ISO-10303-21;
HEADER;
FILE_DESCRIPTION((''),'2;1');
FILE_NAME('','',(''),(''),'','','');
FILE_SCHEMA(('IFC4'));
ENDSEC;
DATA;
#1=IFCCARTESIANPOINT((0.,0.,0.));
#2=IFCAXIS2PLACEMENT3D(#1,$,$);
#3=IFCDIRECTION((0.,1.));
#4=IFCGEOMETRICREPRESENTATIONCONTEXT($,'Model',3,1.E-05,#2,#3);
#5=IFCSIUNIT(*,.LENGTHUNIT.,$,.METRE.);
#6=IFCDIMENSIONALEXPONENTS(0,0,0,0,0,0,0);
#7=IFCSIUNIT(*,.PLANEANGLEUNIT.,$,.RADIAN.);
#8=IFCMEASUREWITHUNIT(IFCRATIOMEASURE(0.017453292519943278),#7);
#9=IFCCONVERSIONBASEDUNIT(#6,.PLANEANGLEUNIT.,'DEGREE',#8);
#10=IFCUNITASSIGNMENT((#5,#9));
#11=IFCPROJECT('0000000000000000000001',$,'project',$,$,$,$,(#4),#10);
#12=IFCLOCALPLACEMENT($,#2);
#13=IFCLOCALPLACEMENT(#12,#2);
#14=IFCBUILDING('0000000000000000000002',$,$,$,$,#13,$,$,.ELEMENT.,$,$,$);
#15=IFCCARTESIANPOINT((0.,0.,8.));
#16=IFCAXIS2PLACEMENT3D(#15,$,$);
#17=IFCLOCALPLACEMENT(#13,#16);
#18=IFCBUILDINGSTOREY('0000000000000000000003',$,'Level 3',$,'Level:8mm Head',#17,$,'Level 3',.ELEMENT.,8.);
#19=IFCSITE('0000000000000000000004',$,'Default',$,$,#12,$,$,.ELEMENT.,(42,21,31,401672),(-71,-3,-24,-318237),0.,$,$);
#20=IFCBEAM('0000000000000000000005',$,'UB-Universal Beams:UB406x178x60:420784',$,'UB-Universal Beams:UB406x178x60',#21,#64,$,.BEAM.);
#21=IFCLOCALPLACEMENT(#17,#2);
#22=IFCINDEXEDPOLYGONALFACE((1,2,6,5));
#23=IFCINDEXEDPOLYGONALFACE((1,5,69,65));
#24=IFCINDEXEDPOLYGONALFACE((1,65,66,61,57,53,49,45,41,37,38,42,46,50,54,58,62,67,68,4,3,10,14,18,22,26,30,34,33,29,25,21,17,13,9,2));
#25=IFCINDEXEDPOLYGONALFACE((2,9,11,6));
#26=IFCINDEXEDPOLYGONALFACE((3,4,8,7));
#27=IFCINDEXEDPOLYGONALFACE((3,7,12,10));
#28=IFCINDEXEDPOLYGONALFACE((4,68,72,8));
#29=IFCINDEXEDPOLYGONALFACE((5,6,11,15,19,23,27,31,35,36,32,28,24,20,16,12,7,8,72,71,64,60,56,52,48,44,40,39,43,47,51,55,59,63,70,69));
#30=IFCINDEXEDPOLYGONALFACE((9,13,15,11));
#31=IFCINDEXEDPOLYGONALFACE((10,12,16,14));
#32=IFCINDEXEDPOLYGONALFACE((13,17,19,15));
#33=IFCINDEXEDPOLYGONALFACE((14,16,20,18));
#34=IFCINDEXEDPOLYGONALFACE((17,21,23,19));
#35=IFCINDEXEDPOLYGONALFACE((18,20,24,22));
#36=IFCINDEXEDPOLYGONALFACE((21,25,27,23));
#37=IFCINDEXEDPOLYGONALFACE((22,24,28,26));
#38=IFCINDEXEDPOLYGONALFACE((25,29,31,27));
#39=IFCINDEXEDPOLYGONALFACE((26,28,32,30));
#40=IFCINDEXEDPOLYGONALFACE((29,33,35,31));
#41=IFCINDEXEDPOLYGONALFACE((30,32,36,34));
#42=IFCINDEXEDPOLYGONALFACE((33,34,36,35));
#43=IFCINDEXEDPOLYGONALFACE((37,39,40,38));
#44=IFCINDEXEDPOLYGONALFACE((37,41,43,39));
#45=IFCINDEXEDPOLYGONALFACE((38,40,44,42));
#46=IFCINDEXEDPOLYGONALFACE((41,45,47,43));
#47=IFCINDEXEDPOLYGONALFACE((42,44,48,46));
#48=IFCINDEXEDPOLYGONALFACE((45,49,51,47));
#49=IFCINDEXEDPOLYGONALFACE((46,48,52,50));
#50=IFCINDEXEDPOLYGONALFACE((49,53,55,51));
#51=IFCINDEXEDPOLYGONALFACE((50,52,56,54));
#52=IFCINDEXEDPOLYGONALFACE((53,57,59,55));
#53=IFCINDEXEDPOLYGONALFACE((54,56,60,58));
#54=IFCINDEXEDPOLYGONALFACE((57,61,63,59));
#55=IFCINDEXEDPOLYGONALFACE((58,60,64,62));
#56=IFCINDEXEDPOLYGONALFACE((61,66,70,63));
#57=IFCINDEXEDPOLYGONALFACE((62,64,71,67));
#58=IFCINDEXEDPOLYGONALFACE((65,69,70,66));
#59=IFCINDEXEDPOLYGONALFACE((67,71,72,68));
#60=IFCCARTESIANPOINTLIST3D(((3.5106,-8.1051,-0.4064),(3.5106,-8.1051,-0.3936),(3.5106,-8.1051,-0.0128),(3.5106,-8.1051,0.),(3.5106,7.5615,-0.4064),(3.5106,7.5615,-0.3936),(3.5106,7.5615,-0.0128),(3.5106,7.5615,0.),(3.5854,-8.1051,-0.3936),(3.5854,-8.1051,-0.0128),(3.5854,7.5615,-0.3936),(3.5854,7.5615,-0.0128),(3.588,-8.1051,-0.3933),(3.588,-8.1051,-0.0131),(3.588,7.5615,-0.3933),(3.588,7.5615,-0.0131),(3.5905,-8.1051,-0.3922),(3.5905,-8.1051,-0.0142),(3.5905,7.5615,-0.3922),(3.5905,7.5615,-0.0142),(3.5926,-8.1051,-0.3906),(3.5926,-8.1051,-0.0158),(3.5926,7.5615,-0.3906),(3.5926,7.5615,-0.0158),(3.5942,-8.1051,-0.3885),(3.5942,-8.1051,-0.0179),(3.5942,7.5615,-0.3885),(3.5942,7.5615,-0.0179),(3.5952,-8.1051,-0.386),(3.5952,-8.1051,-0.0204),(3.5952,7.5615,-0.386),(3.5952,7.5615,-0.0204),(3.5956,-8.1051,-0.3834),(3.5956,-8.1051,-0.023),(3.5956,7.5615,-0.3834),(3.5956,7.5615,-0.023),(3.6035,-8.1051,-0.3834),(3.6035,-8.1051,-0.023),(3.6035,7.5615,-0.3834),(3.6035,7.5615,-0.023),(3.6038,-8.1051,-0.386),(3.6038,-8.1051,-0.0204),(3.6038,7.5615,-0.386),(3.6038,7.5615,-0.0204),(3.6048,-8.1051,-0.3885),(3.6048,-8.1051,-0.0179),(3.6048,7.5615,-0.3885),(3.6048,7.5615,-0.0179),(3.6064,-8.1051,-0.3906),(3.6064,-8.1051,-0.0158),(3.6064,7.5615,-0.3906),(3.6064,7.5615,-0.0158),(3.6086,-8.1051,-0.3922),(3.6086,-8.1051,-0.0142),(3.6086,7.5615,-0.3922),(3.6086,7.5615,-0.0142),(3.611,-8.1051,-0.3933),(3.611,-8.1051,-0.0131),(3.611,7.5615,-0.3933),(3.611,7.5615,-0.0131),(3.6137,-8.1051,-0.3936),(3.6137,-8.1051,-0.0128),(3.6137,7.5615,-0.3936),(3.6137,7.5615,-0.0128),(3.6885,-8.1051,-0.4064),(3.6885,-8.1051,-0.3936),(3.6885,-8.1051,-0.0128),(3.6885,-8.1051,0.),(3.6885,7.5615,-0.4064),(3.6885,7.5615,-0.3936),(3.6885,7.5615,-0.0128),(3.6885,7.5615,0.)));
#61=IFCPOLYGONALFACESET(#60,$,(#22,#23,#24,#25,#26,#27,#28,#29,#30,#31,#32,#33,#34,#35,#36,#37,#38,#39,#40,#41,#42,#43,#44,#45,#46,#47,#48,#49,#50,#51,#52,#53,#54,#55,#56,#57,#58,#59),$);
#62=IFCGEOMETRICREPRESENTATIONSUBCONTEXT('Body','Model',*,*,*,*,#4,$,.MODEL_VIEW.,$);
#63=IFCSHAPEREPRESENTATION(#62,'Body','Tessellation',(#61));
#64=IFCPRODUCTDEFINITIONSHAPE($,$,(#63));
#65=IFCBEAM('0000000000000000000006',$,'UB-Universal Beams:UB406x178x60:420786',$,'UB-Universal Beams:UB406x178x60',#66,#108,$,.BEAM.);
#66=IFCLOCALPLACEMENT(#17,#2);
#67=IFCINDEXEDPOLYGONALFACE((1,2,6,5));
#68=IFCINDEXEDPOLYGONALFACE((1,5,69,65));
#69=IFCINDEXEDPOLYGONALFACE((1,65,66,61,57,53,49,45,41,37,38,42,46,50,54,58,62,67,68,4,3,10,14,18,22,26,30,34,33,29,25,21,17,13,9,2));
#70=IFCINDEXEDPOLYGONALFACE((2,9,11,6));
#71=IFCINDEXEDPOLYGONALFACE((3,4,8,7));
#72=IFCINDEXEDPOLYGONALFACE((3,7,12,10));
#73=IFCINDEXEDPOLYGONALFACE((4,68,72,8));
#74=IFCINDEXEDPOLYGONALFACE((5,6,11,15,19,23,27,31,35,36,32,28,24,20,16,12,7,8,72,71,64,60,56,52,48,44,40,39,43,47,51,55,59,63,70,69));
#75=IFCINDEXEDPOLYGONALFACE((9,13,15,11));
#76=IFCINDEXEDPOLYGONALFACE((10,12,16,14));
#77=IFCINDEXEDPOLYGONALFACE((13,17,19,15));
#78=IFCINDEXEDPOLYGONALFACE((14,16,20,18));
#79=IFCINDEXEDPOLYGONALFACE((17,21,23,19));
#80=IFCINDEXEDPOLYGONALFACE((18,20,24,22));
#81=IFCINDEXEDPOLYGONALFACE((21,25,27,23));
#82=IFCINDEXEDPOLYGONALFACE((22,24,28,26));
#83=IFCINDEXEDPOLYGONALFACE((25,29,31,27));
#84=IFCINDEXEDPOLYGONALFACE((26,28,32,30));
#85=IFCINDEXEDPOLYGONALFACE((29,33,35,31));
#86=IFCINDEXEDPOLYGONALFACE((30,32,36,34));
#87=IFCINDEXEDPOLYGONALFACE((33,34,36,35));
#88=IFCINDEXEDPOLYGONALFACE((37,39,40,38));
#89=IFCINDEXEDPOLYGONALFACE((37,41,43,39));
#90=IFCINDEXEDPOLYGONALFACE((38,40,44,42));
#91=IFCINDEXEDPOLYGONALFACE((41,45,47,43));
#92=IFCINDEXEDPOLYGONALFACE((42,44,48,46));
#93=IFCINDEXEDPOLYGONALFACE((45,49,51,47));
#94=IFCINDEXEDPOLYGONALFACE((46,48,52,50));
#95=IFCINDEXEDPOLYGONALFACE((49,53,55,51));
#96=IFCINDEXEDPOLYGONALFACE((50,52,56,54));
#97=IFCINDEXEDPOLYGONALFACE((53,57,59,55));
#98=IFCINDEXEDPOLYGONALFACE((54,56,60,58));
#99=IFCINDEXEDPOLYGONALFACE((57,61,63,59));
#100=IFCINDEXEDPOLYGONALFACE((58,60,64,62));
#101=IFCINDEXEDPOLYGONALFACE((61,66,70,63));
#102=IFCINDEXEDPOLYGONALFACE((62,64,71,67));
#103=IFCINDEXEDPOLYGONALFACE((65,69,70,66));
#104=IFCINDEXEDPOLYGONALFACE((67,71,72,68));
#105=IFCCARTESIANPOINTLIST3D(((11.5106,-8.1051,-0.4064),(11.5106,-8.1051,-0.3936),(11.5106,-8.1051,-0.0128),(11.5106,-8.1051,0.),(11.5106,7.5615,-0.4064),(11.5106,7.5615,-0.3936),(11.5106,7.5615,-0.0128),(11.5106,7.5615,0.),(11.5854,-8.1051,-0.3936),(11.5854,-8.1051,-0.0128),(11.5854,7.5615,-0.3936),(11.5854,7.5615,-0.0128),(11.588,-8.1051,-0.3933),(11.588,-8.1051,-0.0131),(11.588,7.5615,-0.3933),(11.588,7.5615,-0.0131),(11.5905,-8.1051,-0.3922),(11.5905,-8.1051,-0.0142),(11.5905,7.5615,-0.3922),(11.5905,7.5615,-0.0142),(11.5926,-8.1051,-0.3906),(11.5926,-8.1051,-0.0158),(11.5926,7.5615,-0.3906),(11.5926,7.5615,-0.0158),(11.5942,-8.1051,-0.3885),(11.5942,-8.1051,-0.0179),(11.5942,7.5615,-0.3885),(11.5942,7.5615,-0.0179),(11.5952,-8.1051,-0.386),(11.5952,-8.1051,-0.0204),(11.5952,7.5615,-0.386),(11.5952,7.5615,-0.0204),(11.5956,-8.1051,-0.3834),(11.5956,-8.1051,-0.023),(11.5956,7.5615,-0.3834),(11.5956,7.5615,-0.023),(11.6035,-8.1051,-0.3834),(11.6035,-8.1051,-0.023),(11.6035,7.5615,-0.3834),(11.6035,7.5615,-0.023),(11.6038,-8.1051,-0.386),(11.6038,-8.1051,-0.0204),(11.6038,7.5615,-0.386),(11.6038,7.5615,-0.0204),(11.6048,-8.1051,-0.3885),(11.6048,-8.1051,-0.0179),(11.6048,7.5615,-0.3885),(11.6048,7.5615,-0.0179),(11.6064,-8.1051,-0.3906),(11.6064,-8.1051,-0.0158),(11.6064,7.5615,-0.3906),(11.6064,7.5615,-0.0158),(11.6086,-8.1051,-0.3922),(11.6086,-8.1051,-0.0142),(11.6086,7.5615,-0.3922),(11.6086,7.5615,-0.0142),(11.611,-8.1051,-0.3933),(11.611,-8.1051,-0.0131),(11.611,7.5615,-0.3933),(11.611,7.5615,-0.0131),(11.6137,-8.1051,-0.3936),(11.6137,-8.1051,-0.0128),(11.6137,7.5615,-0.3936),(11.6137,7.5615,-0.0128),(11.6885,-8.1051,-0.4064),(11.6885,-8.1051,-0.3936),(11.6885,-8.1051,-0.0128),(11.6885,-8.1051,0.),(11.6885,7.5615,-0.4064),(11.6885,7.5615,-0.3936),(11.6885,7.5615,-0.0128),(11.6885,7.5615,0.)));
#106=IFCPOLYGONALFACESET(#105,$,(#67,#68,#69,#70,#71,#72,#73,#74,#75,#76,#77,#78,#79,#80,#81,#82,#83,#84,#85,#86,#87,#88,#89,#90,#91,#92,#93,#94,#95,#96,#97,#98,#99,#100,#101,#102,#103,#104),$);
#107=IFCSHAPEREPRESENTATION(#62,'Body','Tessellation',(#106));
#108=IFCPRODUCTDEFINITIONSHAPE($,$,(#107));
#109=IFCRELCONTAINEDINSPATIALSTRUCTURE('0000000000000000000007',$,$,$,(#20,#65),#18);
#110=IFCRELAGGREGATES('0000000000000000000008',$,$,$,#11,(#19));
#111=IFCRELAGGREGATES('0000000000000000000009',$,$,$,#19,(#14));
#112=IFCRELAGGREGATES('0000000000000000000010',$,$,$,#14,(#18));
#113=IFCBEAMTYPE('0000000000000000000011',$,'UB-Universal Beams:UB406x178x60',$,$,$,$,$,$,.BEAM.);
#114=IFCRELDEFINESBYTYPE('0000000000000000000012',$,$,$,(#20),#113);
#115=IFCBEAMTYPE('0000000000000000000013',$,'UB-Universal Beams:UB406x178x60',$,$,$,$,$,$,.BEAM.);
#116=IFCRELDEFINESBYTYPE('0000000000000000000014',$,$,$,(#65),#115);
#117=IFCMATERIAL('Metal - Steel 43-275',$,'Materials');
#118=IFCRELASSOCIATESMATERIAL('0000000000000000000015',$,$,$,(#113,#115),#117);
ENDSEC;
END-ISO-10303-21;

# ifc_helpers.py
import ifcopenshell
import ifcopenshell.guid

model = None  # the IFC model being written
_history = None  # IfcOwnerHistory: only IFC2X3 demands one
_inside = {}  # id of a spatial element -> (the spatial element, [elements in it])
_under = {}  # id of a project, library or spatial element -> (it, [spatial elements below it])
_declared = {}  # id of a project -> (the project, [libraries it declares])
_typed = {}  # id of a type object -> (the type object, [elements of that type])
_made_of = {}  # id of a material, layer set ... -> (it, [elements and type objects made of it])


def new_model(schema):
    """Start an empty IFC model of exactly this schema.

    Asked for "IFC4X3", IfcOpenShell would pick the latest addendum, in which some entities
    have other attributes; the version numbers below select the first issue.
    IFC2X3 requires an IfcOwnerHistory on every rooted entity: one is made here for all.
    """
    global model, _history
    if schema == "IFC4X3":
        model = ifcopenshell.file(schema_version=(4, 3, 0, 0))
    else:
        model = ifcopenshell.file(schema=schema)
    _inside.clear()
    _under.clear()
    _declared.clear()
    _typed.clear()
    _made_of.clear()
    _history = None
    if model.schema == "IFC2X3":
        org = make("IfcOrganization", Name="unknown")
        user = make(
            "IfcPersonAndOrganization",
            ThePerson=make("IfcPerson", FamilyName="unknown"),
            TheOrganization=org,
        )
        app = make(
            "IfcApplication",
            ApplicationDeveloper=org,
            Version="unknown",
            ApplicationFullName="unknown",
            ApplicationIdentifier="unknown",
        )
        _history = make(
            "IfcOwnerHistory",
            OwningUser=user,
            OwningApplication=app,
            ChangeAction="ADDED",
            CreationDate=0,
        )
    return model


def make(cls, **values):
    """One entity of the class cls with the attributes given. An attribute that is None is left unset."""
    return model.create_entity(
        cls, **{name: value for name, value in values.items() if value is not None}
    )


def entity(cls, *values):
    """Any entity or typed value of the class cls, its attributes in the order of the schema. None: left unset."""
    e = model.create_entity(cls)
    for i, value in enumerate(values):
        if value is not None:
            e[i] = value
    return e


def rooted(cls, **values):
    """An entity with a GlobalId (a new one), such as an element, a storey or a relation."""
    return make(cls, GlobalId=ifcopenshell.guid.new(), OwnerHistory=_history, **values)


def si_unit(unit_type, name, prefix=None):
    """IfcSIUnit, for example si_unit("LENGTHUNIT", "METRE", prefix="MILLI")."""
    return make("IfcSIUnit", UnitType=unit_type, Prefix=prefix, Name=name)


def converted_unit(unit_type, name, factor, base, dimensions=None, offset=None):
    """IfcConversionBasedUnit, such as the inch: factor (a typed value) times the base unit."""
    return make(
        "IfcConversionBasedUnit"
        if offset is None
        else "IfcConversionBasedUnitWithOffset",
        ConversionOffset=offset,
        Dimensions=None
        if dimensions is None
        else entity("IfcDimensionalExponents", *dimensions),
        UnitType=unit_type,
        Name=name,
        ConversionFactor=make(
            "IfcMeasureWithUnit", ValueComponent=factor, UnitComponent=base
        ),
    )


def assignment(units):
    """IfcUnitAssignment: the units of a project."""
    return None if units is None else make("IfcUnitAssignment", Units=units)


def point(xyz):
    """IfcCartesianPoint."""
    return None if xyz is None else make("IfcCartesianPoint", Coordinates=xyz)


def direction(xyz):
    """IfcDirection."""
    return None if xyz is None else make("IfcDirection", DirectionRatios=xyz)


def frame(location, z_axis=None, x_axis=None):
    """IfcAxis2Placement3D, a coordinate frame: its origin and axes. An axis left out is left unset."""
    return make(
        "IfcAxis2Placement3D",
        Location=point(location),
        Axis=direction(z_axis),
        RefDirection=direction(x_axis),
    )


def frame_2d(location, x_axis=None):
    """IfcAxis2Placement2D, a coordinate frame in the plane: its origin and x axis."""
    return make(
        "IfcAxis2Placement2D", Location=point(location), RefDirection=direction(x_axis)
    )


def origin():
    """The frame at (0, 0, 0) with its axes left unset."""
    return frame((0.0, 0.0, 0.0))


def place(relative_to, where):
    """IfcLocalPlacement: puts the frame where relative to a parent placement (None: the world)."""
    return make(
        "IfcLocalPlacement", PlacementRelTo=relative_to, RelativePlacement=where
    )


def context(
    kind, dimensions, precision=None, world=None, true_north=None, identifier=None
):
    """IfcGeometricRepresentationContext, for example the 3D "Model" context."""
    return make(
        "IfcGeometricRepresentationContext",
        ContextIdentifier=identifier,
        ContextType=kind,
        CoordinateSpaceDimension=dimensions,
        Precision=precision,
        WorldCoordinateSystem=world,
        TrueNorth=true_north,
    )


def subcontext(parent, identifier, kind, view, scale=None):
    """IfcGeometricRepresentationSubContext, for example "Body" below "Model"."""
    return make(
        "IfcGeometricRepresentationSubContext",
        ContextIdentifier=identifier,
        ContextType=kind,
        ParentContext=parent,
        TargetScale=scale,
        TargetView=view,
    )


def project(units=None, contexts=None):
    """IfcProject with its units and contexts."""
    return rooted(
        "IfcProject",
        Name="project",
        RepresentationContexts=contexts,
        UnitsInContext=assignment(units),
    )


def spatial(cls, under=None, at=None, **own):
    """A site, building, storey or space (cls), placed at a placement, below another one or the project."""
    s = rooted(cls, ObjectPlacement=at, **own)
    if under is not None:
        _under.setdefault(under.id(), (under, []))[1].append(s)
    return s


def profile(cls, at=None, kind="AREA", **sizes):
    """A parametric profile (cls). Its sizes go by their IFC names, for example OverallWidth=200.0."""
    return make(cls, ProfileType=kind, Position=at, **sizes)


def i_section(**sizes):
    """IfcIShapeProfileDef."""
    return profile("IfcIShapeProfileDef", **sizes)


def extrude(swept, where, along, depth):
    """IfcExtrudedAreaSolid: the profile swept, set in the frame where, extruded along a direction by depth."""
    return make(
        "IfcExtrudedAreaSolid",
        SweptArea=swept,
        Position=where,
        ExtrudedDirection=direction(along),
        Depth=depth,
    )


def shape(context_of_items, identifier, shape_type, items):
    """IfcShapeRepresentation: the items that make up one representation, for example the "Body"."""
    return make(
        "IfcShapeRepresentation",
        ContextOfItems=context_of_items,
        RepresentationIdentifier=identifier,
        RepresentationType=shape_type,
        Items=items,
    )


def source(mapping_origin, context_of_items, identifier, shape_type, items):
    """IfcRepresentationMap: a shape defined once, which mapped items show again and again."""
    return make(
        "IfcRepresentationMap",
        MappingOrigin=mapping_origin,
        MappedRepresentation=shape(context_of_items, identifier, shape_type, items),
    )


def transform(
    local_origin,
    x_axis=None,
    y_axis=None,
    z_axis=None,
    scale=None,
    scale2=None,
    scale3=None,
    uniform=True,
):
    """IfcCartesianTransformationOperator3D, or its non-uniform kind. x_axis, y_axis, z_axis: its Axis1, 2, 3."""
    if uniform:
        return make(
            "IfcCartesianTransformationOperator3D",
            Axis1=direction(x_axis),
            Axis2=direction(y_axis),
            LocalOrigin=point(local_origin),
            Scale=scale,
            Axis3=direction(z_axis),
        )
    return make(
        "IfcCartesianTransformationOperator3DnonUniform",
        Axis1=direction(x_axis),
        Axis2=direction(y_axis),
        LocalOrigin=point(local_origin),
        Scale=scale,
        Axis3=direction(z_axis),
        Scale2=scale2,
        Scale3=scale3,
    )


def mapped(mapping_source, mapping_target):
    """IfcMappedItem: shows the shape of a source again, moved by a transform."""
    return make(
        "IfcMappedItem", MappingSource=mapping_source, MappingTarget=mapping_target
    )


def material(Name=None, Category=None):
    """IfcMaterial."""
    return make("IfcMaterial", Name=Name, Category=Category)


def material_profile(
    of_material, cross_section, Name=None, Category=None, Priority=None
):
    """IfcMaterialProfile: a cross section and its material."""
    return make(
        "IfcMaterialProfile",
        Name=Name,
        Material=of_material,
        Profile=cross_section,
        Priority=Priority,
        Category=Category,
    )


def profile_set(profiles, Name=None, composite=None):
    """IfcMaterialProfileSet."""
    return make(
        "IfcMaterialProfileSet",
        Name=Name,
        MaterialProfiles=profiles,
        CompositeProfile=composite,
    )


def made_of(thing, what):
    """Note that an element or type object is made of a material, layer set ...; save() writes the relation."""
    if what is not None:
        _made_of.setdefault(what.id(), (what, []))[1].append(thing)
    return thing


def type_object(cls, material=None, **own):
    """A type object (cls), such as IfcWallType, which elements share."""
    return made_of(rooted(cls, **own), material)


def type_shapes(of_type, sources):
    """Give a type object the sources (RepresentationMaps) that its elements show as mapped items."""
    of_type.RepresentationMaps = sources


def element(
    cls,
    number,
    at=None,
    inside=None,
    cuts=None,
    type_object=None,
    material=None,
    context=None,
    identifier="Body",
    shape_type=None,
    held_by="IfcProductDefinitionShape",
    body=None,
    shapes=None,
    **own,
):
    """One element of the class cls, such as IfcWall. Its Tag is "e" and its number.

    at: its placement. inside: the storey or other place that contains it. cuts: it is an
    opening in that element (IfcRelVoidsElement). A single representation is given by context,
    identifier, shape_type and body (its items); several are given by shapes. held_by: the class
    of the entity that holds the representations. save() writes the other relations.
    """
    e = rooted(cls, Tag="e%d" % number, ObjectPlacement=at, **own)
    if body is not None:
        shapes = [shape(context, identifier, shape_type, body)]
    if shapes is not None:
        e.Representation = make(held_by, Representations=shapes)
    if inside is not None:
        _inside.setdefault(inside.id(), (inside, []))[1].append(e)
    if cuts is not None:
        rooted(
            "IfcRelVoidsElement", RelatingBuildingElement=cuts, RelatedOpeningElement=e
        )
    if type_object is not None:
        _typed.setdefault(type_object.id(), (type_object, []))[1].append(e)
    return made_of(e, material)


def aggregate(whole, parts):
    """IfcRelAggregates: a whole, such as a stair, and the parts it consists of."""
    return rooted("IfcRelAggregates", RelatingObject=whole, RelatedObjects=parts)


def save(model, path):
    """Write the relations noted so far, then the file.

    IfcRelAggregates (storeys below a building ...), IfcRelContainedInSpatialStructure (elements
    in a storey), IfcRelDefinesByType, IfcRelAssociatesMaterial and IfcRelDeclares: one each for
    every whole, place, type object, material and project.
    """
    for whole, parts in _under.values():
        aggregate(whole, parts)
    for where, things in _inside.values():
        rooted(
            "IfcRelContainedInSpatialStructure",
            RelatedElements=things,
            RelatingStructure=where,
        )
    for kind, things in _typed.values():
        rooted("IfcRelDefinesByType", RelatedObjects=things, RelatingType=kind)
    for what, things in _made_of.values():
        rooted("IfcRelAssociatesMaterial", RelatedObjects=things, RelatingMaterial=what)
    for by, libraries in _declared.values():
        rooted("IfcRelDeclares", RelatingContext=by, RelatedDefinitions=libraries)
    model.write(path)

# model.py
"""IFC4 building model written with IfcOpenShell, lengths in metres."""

from ifc_helpers import new_model, entity, si_unit, converted_unit, direction, frame, frame_2d, origin, place, context, subcontext, project, spatial, i_section, extrude, source, transform, mapped, material, material_profile, profile_set, type_object, type_shapes, element, save


model = new_model("IFC4")

# Units and contexts
model_context = context("Model", 3, precision=1e-05, world=origin(), true_north=direction((0.0, 1.0)))
body_context = subcontext(model_context, "Body", "Model", "MODEL_VIEW")
ifc_project = project(units=[si_unit("LENGTHUNIT", "METRE"), converted_unit("PLANEANGLEUNIT", "DEGREE", entity("IfcRatioMeasure", 0.017453292519943278), si_unit("PLANEANGLEUNIT", "RADIAN"), dimensions=[0, 0, 0, 0, 0, 0, 0])], contexts=[model_context])

# Site, building, storey
site_placement = place(None, origin())
site = spatial("IfcSite", under=ifc_project, at=site_placement, Name="Default", CompositionType="ELEMENT", RefLatitude=(42, 21, 31, 401672), RefLongitude=(-71, -3, -24, -318237), RefElevation=0.0)
building_placement = place(site_placement, origin())
building = spatial("IfcBuilding", under=site, at=building_placement, CompositionType="ELEMENT")
storey_placement = place(building_placement, frame((0.0, 0.0, 8.0)))
storey = spatial("IfcBuildingStorey", under=building, at=storey_placement, Name="Level 3", ObjectType="Level:8mm Head", LongName="Level 3", CompositionType="ELEMENT", Elevation=8.0)

# Shared definitions
ifc_material_1 = material(Name="Metal - Steel 43-275", Category="Materials")
ifc_material_profile_1 = material_profile(ifc_material_1, i_section(OverallWidth=0.1779, OverallDepth=0.4064, WebThickness=0.0079, FlangeThickness=0.0128, FilletRadius=0.0102, at=frame_2d((0.0, 0.0), x_axis=(0.0, 1.0))), Name="UB406x178x60")
ifc_profile_set_1 = profile_set([ifc_material_profile_1], Name="UB406x178x60")

# Beams
beam_type_1 = type_object("IfcBeamType", Name="UB-Universal Beams:UB406x178x60", PredefinedType="BEAM", material=ifc_profile_set_1)
shared_shape_1 = source(origin(), body_context, "Body", "SweptSolid", [
    extrude(i_section(OverallWidth=0.1779, OverallDepth=0.4064, WebThickness=0.0079, FlangeThickness=0.0128, FilletRadius=0.0102, at=frame_2d((0.0, 0.0), x_axis=(1.0, 0.0))), frame((3.5995, -8.1051, 7.7968), z_axis=(0.0, 1.0, 0.0), x_axis=(-1.0, 0.0, 0.0)), (0.0, 0.0, 1.0), 15.6666),
])
type_shapes(beam_type_1, [shared_shape_1])
beam_1_placement = place(storey_placement, frame((0.0, 0.0, -8.0)))
element("IfcBeam", 1, at=beam_1_placement, inside=storey, type_object=beam_type_1, Name="UB-Universal Beams:UB406x178x60:420784", ObjectType="UB-Universal Beams:UB406x178x60", PredefinedType="BEAM", context=body_context, shape_type="MappedRepresentation", body=[
    mapped(shared_shape_1, transform((0.0, 0.0, 0.0), scale=1.0)),
])
beam_type_2 = type_object("IfcBeamType", Name="UB-Universal Beams:UB406x178x60", PredefinedType="BEAM", material=ifc_profile_set_1)
shared_shape_2 = source(origin(), body_context, "Body", "SweptSolid", [
    extrude(i_section(OverallWidth=0.1779, OverallDepth=0.4064, WebThickness=0.0079, FlangeThickness=0.0128, FilletRadius=0.0102, at=frame_2d((0.0, 0.0), x_axis=(1.0, 0.0))), frame((11.5995, -8.1051, 7.7968), z_axis=(0.0, 1.0, 0.0), x_axis=(-1.0, 0.0, 0.0)), (0.0, 0.0, 1.0), 15.6666),
])
type_shapes(beam_type_2, [shared_shape_2])
beam_2_placement = place(storey_placement, frame((0.0, 0.0, -8.0)))
element("IfcBeam", 2, at=beam_2_placement, inside=storey, type_object=beam_type_2, Name="UB-Universal Beams:UB406x178x60:420786", ObjectType="UB-Universal Beams:UB406x178x60", PredefinedType="BEAM", context=body_context, shape_type="MappedRepresentation", body=[
    mapped(shared_shape_2, transform((0.0, 0.0, 0.0), scale=1.0)),
])

save(model, "model.ifc")
